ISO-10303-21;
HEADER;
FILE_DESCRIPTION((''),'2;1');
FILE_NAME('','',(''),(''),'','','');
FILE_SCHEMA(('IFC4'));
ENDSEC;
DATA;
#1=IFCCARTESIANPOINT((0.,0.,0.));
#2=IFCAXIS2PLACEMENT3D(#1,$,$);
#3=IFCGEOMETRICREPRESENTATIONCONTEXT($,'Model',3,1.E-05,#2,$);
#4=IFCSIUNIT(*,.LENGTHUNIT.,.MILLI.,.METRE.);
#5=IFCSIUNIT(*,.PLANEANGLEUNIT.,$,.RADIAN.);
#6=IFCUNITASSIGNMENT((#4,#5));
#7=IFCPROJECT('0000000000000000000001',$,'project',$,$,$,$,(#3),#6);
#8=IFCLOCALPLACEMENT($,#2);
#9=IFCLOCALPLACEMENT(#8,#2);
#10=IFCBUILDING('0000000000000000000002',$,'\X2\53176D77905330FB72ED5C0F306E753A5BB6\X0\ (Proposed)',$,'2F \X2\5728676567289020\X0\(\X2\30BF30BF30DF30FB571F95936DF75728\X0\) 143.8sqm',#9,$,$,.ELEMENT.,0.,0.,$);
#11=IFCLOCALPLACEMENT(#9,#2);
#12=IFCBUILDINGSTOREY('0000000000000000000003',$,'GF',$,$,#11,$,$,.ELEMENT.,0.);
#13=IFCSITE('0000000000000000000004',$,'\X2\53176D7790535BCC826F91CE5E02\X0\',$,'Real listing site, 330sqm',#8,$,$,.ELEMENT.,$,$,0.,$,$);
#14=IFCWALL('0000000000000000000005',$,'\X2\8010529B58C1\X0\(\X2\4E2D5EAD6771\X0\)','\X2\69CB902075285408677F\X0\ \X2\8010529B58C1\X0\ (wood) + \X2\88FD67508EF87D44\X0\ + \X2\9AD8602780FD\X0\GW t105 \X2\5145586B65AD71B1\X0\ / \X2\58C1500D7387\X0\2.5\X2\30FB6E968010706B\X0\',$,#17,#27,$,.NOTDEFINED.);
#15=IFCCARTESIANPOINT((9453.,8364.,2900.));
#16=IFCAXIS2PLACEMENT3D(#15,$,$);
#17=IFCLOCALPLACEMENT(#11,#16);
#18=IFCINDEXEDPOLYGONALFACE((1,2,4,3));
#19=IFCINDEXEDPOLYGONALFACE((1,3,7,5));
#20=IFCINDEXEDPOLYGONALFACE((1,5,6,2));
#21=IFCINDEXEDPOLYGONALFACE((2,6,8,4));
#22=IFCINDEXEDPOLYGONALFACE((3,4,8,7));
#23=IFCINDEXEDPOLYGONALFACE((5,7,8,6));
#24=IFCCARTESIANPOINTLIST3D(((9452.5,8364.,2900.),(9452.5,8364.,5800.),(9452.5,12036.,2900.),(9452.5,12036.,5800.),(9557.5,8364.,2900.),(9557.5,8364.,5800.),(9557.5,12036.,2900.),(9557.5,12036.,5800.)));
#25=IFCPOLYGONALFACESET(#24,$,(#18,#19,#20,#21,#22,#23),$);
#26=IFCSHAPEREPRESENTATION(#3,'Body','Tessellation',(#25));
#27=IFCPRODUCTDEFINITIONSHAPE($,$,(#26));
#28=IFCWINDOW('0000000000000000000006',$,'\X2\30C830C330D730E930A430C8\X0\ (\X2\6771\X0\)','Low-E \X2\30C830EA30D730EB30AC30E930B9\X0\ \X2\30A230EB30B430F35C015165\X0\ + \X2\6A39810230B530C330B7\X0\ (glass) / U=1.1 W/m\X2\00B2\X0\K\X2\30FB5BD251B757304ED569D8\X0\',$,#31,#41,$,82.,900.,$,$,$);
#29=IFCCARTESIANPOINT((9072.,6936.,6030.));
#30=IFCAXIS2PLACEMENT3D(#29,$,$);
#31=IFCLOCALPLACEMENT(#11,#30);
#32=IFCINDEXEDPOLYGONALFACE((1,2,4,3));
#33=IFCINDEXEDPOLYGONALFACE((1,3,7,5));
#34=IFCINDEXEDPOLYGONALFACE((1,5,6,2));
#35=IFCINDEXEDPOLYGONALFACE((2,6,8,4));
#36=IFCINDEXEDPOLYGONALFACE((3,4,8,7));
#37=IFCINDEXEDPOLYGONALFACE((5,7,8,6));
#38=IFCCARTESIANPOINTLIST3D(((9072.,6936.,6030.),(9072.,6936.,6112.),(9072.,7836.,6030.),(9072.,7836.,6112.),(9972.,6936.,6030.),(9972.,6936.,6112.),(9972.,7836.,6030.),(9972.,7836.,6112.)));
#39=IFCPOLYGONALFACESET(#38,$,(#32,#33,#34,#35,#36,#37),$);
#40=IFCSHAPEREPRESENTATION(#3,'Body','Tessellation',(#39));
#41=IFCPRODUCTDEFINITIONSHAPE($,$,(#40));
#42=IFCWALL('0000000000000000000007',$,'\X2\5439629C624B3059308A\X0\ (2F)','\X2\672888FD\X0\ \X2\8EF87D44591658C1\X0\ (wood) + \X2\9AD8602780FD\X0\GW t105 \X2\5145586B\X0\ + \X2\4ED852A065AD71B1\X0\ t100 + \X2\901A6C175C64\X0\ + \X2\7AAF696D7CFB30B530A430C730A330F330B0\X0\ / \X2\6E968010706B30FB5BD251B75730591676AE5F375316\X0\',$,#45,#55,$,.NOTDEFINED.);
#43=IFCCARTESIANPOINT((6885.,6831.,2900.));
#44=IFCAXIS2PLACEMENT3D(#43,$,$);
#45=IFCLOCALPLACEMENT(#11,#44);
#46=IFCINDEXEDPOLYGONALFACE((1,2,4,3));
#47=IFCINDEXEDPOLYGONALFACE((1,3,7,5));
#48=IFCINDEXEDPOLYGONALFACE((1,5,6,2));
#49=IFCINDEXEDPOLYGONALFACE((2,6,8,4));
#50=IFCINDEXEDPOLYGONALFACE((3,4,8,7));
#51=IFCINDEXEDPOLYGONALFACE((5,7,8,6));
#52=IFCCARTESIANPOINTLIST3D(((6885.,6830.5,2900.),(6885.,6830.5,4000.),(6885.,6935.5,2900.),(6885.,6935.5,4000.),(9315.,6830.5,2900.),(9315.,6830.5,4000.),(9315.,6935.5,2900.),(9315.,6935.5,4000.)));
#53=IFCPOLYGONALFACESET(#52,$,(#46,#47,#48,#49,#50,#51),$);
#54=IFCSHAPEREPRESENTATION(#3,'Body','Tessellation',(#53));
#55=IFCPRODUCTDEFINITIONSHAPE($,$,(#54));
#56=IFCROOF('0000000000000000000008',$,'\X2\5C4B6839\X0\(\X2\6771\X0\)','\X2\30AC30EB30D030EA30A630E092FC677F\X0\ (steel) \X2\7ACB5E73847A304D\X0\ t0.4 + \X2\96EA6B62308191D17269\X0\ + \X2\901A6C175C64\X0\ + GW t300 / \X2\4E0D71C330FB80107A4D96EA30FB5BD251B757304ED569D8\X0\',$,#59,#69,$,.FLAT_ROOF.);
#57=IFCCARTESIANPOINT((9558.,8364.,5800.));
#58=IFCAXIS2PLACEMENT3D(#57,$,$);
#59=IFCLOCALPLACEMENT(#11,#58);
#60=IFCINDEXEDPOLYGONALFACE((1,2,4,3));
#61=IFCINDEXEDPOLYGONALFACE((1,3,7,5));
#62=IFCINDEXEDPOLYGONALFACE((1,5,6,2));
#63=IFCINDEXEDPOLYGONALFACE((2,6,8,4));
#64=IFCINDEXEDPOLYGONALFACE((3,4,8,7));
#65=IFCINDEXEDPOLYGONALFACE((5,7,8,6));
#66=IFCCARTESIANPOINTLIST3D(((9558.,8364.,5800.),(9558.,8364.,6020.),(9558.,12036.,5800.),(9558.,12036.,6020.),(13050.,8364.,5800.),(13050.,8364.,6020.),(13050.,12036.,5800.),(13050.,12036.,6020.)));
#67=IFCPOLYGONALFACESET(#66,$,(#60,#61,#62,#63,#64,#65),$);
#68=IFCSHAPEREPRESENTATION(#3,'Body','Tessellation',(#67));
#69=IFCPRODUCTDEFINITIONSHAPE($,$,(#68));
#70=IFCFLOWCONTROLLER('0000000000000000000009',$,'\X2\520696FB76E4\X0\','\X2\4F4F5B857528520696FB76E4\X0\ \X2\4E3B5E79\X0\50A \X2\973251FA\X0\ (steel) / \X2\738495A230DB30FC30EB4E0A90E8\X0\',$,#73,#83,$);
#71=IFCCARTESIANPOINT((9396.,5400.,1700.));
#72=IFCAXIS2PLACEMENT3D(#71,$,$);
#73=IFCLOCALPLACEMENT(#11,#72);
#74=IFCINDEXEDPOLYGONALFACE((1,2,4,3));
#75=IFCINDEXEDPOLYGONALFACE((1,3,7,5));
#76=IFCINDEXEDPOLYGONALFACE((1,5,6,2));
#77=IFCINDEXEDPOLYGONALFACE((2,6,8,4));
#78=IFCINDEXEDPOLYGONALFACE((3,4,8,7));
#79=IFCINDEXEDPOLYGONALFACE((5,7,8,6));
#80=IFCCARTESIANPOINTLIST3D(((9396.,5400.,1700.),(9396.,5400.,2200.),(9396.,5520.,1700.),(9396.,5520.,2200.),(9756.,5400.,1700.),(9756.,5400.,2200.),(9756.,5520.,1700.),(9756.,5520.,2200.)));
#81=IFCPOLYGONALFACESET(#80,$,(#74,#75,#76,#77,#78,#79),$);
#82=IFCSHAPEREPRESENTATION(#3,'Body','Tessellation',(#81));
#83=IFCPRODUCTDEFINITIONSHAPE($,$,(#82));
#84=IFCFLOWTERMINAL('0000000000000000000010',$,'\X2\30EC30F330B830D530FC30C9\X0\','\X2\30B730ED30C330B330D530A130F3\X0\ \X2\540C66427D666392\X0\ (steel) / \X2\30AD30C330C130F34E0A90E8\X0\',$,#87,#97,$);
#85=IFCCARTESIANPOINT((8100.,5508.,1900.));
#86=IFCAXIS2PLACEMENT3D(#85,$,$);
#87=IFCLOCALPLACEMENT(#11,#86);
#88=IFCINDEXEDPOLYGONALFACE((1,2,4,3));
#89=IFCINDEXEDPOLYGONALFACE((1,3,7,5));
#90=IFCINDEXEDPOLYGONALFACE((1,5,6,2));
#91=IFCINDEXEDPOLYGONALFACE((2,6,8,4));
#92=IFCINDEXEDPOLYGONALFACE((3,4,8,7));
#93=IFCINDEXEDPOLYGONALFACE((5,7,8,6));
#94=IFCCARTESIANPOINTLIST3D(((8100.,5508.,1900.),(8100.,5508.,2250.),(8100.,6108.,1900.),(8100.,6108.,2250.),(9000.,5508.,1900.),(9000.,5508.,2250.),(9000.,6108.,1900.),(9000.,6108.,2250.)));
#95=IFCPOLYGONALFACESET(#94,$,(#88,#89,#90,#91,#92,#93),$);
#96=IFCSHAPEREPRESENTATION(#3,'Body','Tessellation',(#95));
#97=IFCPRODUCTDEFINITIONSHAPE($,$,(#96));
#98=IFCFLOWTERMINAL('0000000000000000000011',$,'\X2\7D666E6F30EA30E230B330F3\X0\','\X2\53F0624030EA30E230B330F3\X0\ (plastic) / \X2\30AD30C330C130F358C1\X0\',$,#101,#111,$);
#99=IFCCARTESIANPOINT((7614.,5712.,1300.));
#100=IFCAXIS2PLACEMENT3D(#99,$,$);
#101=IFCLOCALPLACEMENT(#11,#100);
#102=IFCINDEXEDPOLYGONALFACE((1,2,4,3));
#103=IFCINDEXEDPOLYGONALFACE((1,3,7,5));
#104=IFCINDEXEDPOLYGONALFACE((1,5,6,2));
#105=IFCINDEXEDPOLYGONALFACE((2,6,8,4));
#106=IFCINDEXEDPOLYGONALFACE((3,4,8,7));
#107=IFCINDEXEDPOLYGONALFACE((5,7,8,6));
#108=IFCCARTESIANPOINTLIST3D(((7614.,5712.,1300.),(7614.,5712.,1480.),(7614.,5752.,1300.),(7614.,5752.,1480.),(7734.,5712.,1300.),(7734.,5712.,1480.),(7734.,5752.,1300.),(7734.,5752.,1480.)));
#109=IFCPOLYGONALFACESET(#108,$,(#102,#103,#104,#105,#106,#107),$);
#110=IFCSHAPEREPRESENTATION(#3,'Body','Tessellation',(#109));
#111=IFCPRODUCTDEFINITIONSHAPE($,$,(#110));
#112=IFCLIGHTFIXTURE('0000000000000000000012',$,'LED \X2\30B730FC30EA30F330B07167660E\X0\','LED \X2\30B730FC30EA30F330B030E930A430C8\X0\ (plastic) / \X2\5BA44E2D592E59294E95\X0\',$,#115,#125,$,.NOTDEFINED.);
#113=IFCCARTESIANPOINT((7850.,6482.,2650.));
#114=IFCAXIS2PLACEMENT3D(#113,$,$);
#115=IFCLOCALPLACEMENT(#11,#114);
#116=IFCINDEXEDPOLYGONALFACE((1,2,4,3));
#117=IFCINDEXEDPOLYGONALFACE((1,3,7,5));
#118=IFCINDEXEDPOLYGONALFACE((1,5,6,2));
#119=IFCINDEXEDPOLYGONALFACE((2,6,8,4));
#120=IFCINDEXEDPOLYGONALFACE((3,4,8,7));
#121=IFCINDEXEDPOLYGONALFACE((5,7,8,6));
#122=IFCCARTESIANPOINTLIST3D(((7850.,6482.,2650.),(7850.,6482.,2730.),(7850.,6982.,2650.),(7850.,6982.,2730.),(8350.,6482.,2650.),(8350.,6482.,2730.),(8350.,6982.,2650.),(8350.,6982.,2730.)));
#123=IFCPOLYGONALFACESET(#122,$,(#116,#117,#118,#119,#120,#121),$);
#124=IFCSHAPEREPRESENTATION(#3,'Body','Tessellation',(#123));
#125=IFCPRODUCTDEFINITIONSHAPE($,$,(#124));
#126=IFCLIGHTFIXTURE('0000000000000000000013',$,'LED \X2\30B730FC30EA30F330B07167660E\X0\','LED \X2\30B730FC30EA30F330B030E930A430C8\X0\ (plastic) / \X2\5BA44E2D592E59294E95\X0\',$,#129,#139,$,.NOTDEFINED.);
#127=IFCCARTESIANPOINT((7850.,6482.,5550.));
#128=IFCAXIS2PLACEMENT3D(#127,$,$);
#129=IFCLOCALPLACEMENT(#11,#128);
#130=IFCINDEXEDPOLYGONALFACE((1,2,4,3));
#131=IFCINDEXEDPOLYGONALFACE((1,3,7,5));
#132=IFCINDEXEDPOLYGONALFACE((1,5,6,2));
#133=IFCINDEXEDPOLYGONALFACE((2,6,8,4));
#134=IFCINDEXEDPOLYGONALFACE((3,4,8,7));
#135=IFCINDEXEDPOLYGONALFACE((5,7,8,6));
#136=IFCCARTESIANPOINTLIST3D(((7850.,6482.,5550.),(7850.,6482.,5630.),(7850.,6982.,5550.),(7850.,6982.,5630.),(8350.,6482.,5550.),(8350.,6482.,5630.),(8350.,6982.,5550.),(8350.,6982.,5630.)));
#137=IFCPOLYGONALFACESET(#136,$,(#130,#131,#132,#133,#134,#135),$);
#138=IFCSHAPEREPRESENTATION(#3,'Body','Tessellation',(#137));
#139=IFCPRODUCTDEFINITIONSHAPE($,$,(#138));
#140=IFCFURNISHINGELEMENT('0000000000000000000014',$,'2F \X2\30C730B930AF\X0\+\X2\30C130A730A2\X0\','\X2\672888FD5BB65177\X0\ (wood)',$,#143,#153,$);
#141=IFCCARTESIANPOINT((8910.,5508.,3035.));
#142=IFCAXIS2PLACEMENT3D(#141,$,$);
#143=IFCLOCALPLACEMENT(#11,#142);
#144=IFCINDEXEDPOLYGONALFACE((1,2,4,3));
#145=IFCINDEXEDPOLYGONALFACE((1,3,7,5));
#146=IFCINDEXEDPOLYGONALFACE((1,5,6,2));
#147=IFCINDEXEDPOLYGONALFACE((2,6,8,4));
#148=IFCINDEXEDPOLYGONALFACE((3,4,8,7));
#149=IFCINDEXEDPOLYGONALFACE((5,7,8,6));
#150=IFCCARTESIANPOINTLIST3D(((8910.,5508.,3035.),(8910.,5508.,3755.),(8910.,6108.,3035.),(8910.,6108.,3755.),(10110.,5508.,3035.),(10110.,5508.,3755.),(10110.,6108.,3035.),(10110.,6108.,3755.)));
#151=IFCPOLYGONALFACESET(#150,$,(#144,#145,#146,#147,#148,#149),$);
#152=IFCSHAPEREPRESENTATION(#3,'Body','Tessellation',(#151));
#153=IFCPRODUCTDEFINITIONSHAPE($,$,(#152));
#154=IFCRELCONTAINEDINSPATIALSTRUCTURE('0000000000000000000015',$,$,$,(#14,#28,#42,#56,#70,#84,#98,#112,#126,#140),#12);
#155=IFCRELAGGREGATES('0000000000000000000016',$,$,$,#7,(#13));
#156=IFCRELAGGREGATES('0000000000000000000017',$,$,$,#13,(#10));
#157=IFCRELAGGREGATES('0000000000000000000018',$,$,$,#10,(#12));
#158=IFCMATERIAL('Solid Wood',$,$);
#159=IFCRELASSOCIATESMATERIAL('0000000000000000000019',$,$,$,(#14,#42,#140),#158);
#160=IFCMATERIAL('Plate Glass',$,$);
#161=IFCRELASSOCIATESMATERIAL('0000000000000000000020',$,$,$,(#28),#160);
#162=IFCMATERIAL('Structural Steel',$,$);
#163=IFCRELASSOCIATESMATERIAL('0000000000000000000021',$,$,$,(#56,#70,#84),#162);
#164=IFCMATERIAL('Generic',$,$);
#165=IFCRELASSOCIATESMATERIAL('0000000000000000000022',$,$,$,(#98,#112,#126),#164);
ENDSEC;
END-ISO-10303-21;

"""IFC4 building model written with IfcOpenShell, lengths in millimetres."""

from ifc_helpers import new_model, si_unit, frame, frame_2d, origin, place, context, project, spatial, rectangle, extrude, material, element, save


model = new_model("IFC4")

# Units and contexts
model_context = context("Model", 3, precision=1e-05, world=origin())
ifc_project = project(units=[si_unit("LENGTHUNIT", "METRE", prefix="MILLI"), si_unit("PLANEANGLEUNIT", "RADIAN")], contexts=[model_context])

# Site, building, storey
site_placement = place(None, origin())
site = spatial("IfcSite", under=ifc_project, at=site_placement, Name="北海道富良野市", ObjectType="Real listing site, 330sqm", CompositionType="ELEMENT", RefElevation=0.0)
building_placement = place(site_placement, origin())
building = spatial("IfcBuilding", under=site, at=building_placement, Name="北海道・狭小の町家 (Proposed)", ObjectType="2F 在来木造(タタミ・土間混在) 143.8sqm", CompositionType="ELEMENT", ElevationOfRefHeight=0.0, ElevationOfTerrain=0.0)
storey_placement = place(building_placement, origin())
storey = spatial("IfcBuildingStorey", under=building, at=storey_placement, Name="GF", CompositionType="ELEMENT", Elevation=0.0)

# Shared definitions
ifc_material_1 = material(Name="Solid Wood")

# Shared definitions
ifc_material_2 = material(Name="Plate Glass")

# Wall
wall_1_placement = place(storey_placement, frame((9453.0, 8364.0, 2900.0)))
element("IfcWall", 1, at=wall_1_placement, inside=storey, material=ifc_material_1, Name="耐力壁(中庭東)", Description="構造用合板 耐力壁 (wood) + 製材軸組 + 高性能GW t105 充填断熱 / 壁倍率2.5・準耐火", PredefinedType="NOTDEFINED", context=model_context, shape_type="SweptSolid", body=[
    extrude(rectangle(XDim=105.0, YDim=3672.0, at=frame_2d((52.0, 1836.0))), frame((9453.0, 8364.0, 2900.0)), (0.0, 0.0, 1.0), 2900.0),
])

# Window
window_1_placement = place(storey_placement, frame((9072.0, 6936.0, 6030.0)))
element("IfcWindow", 2, at=window_1_placement, inside=storey, material=ifc_material_2, Name="トップライト (東)", Description="Low-E トリプルガラス アルゴン封入 + 樹脂サッシ (glass) / U=1.1 W/m²K・寒冷地仕様", OverallHeight=82.0, OverallWidth=900.0, context=model_context, shape_type="SweptSolid", body=[
    extrude(rectangle(XDim=900.0, YDim=900.0, at=frame_2d((450.0, 450.0))), frame((9072.0, 6936.0, 6030.0)), (0.0, 0.0, 1.0), 82.0),
])

# Wall
wall_2_placement = place(storey_placement, frame((6885.0, 6831.0, 2900.0)))
element("IfcWall", 3, at=wall_2_placement, inside=storey, material=ifc_material_1, Name="吹抜手すり (2F)", Description="木製 軸組外壁 (wood) + 高性能GW t105 充填 + 付加断熱 t100 + 通気層 + 窯業系サイディング / 準耐火・寒冷地外皮強化", PredefinedType="NOTDEFINED", context=model_context, shape_type="SweptSolid", body=[
    extrude(rectangle(XDim=2430.0, YDim=105.0, at=frame_2d((1215.0, 52.0))), frame((6885.0, 6831.0, 2900.0)), (0.0, 0.0, 1.0), 1100.0),
])

# Roof
ifc_material_3 = material(Name="Structural Steel")
for number, where, name in (
    (4, (9558.0, 8364.0, 5800.0), "屋根(東)"),
):
    element("IfcRoof", number, at=place(storey_placement, frame(where)), inside=storey, material=ifc_material_3, Name=name, Description="ガルバリウム鋼板 (steel) 立平葺き t0.4 + 雪止め金物 + 通気層 + GW t300 / 不燃・耐積雪・寒冷地仕様", PredefinedType="FLAT_ROOF", context=model_context, shape_type="SweptSolid", body=[
        extrude(rectangle(XDim=3492.0, YDim=3672.0, at=frame_2d((1746.0, 1836.0))), frame((9558.0, 8364.0, 5800.0)), (0.0, 0.0, 1.0), 220.0),
    ])

# Flow controller
flow_controller_placement = place(storey_placement, frame((9396.0, 5400.0, 1700.0)))
element("IfcFlowController", 5, at=flow_controller_placement, inside=storey, material=ifc_material_3, Name="分電盤", Description="住宅用分電盤 主幹50A 露出 (steel) / 玄関ホール上部", context=model_context, shape_type="SweptSolid", body=[
    extrude(rectangle(XDim=360.0, YDim=120.0, at=frame_2d((180.0, 60.0))), frame((9396.0, 5400.0, 1700.0)), (0.0, 0.0, 1.0), 500.0),
])

# Flow terminals
flow_terminal_1_placement = place(storey_placement, frame((8100.0, 5508.0, 1900.0)))
element("IfcFlowTerminal", 6, at=flow_terminal_1_placement, inside=storey, material=ifc_material_3, Name="レンジフード", Description="シロッコファン 同時給排 (steel) / キッチン上部", context=model_context, shape_type="SweptSolid", body=[
    extrude(rectangle(XDim=900.0, YDim=600.0, at=frame_2d((450.0, 300.0))), frame((8100.0, 5508.0, 1900.0)), (0.0, 0.0, 1.0), 350.0),
])
ifc_material_4 = material(Name="Generic")
flow_terminal_2_placement = place(storey_placement, frame((7614.0, 5712.0, 1300.0)))
element("IfcFlowTerminal", 7, at=flow_terminal_2_placement, inside=storey, material=ifc_material_4, Name="給湯リモコン", Description="台所リモコン (plastic) / キッチン壁", context=model_context, shape_type="SweptSolid", body=[
    extrude(rectangle(XDim=120.0, YDim=40.0, at=frame_2d((60.0, 20.0))), frame((7614.0, 5712.0, 1300.0)), (0.0, 0.0, 1.0), 180.0),
])

# Light fixtures
light_fixture_1_placement = place(storey_placement, frame((7850.0, 6482.0, 2650.0)))
element("IfcLightFixture", 8, at=light_fixture_1_placement, inside=storey, material=ifc_material_4, Name="LED シーリング照明", Description="LED シーリングライト (plastic) / 室中央天井", PredefinedType="NOTDEFINED", context=model_context, shape_type="SweptSolid", body=[
    extrude(rectangle(XDim=500.0, YDim=500.0, at=frame_2d((250.0, 250.0))), frame((7850.0, 6482.0, 2650.0)), (0.0, 0.0, 1.0), 80.0),
])
light_fixture_2_placement = place(storey_placement, frame((7850.0, 6482.0, 5550.0)))
element("IfcLightFixture", 9, at=light_fixture_2_placement, inside=storey, material=ifc_material_4, Name="LED シーリング照明", Description="LED シーリングライト (plastic) / 室中央天井", PredefinedType="NOTDEFINED", context=model_context, shape_type="SweptSolid", body=[
    extrude(rectangle(XDim=500.0, YDim=500.0, at=frame_2d((250.0, 250.0))), frame((7850.0, 6482.0, 5550.0)), (0.0, 0.0, 1.0), 80.0),
])

# Furnishing element
furnishing_placement = place(storey_placement, frame((8910.0, 5508.0, 3035.0)))
element("IfcFurnishingElement", 10, at=furnishing_placement, inside=storey, material=ifc_material_1, Name="2F デスク+チェア", Description="木製家具 (wood)", context=model_context, shape_type="SweptSolid", body=[
    extrude(rectangle(XDim=1200.0, YDim=600.0, at=frame_2d((600.0, 300.0))), frame((8910.0, 5508.0, 3035.0)), (0.0, 0.0, 1.0), 720.0),
])

save(model, "model.ifc")
